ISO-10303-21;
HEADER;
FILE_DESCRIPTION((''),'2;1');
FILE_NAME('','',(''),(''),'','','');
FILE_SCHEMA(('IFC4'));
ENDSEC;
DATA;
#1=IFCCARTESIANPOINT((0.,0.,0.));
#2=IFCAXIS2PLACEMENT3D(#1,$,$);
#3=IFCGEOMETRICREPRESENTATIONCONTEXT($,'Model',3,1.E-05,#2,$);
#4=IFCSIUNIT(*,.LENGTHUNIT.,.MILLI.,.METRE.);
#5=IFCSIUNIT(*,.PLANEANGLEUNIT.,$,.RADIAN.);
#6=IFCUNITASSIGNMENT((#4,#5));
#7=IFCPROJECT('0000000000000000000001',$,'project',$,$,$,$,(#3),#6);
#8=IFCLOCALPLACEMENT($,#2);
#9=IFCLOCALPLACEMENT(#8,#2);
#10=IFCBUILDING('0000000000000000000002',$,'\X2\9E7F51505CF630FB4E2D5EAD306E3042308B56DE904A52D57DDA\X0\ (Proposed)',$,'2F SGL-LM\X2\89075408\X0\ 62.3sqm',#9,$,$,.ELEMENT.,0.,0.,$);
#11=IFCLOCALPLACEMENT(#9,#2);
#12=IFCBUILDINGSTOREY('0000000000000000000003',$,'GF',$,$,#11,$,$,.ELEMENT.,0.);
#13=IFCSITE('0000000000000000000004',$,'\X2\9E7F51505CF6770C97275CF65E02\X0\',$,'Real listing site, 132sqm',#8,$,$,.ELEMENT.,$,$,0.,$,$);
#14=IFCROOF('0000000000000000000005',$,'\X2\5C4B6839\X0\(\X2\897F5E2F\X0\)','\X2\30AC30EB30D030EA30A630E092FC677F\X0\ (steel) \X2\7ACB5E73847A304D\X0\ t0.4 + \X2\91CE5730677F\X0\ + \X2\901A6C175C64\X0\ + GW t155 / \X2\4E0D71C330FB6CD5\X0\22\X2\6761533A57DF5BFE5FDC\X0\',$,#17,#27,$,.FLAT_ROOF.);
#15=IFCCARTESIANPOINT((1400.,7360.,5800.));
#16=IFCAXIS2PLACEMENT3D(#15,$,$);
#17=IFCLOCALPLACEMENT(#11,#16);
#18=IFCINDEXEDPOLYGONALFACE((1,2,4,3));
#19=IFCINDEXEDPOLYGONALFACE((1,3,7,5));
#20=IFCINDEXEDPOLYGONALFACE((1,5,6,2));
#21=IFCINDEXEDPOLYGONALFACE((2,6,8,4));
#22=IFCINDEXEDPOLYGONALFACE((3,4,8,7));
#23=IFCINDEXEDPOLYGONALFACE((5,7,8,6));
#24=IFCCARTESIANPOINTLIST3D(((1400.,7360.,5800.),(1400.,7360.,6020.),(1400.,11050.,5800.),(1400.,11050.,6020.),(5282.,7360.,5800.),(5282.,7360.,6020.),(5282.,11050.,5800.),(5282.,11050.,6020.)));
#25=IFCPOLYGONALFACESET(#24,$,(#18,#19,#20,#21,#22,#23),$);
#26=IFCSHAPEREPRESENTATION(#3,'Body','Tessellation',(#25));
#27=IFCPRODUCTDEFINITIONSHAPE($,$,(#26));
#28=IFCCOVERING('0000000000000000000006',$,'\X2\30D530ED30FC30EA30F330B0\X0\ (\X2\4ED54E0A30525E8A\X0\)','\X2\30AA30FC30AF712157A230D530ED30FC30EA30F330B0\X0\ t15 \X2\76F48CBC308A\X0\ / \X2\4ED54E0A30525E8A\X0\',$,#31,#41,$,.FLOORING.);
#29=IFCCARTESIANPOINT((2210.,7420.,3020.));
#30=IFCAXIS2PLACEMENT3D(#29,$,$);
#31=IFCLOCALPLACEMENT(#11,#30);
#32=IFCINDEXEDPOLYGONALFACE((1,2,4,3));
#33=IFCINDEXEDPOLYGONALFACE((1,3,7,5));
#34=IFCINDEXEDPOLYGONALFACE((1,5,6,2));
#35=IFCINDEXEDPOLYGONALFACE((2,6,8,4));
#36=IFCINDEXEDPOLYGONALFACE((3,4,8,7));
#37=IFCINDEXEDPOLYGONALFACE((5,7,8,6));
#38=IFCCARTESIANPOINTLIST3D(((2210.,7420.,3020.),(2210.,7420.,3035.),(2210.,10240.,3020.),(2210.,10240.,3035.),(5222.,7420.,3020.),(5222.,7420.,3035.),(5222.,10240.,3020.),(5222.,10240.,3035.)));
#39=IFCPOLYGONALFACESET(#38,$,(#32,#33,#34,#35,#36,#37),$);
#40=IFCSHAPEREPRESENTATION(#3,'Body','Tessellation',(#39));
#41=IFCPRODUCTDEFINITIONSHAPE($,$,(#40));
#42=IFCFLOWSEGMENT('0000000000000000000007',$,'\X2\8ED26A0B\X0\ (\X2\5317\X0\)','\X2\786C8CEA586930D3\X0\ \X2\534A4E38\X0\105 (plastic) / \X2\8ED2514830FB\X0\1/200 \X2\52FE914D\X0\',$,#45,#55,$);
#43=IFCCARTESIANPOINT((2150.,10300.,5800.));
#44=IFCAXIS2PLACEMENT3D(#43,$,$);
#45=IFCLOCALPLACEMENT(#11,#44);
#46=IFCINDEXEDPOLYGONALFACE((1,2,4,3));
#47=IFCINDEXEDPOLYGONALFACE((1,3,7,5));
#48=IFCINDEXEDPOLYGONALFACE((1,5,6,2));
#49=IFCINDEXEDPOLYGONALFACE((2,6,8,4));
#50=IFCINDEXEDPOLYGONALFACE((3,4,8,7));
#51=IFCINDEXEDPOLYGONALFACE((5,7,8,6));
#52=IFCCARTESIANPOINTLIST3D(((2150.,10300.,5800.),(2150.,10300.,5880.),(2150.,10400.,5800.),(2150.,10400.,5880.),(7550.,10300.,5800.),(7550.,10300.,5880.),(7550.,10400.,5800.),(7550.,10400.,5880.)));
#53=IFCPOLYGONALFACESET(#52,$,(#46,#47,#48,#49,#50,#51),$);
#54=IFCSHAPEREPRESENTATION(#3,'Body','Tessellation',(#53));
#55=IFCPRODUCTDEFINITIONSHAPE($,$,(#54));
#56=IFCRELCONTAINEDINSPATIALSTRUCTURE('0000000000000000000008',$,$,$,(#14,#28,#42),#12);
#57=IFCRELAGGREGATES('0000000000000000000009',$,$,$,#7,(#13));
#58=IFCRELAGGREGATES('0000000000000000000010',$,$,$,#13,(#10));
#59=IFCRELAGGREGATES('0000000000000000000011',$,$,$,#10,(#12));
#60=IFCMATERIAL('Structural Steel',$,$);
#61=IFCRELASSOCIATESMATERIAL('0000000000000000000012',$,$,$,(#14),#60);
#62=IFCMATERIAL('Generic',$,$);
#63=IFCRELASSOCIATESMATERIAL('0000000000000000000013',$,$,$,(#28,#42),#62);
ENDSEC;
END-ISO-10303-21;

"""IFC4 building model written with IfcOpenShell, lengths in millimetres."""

from ifc_helpers import new_model, si_unit, frame, frame_2d, origin, place, context, project, spatial, rectangle, extrude, material, element, save


model = new_model("IFC4")

# Units and contexts
model_context = context("Model", 3, precision=1e-05, world=origin())
ifc_project = project(units=[si_unit("LENGTHUNIT", "METRE", prefix="MILLI"), si_unit("PLANEANGLEUNIT", "RADIAN")], contexts=[model_context])

# Site, building, storey
site_placement = place(None, origin())
site = spatial("IfcSite", under=ifc_project, at=site_placement, Name="鹿児島県霧島市", ObjectType="Real listing site, 132sqm", CompositionType="ELEMENT", RefElevation=0.0)
building_placement = place(site_placement, origin())
building = spatial("IfcBuilding", under=site, at=building_placement, Name="鹿児島・中庭のある回遊動線 (Proposed)", ObjectType="2F SGL-LM複合 62.3sqm", CompositionType="ELEMENT", ElevationOfRefHeight=0.0, ElevationOfTerrain=0.0)
storey_placement = place(building_placement, origin())
storey = spatial("IfcBuildingStorey", under=building, at=storey_placement, Name="GF", CompositionType="ELEMENT", Elevation=0.0)

# Roof
ifc_material_1 = material(Name="Structural Steel")
for number, where, name in (
    (1, (1400.0, 7360.0, 5800.0), "屋根(西帯)"),
):
    element("IfcRoof", number, at=place(storey_placement, frame(where)), inside=storey, material=ifc_material_1, Name=name, Description="ガルバリウム鋼板 (steel) 立平葺き t0.4 + 野地板 + 通気層 + GW t155 / 不燃・法22条区域対応", PredefinedType="FLAT_ROOF", context=model_context, shape_type="SweptSolid", body=[
        extrude(rectangle(XDim=3882.0, YDim=3690.0, at=frame_2d((1941.0, 1845.0))), frame((1400.0, 7360.0, 5800.0)), (0.0, 0.0, 1.0), 220.0),
    ])

# Covering
ifc_material_2 = material(Name="Generic")
covering_placement = place(storey_placement, frame((2210.0, 7420.0, 3020.0)))
element("IfcCovering", 2, at=covering_placement, inside=storey, material=ifc_material_2, Name="フローリング (仕上げ床)", Description="オーク無垢フローリング t15 直貼り / 仕上げ床", PredefinedType="FLOORING", context=model_context, shape_type="SweptSolid", body=[
    extrude(rectangle(XDim=3012.0, YDim=2820.0, at=frame_2d((1506.0, 1410.0))), frame((2210.0, 7420.0, 3020.0)), (0.0, 0.0, 1.0), 15.0),
])

# Flow segment
flow_segment_placement = place(storey_placement, frame((2150.0, 10300.0, 5800.0)))
element("IfcFlowSegment", 3, at=flow_segment_placement, inside=storey, material=ifc_material_2, Name="軒樋 (北)", Description="硬質塩ビ 半丸105 (plastic) / 軒先・1/200 勾配", context=model_context, shape_type="SweptSolid", body=[
    extrude(rectangle(XDim=5400.0, YDim=100.0, at=frame_2d((2700.0, 50.0))), frame((2150.0, 10300.0, 5800.0)), (0.0, 0.0, 1.0), 80.0),
])

save(model, "model.ifc")
